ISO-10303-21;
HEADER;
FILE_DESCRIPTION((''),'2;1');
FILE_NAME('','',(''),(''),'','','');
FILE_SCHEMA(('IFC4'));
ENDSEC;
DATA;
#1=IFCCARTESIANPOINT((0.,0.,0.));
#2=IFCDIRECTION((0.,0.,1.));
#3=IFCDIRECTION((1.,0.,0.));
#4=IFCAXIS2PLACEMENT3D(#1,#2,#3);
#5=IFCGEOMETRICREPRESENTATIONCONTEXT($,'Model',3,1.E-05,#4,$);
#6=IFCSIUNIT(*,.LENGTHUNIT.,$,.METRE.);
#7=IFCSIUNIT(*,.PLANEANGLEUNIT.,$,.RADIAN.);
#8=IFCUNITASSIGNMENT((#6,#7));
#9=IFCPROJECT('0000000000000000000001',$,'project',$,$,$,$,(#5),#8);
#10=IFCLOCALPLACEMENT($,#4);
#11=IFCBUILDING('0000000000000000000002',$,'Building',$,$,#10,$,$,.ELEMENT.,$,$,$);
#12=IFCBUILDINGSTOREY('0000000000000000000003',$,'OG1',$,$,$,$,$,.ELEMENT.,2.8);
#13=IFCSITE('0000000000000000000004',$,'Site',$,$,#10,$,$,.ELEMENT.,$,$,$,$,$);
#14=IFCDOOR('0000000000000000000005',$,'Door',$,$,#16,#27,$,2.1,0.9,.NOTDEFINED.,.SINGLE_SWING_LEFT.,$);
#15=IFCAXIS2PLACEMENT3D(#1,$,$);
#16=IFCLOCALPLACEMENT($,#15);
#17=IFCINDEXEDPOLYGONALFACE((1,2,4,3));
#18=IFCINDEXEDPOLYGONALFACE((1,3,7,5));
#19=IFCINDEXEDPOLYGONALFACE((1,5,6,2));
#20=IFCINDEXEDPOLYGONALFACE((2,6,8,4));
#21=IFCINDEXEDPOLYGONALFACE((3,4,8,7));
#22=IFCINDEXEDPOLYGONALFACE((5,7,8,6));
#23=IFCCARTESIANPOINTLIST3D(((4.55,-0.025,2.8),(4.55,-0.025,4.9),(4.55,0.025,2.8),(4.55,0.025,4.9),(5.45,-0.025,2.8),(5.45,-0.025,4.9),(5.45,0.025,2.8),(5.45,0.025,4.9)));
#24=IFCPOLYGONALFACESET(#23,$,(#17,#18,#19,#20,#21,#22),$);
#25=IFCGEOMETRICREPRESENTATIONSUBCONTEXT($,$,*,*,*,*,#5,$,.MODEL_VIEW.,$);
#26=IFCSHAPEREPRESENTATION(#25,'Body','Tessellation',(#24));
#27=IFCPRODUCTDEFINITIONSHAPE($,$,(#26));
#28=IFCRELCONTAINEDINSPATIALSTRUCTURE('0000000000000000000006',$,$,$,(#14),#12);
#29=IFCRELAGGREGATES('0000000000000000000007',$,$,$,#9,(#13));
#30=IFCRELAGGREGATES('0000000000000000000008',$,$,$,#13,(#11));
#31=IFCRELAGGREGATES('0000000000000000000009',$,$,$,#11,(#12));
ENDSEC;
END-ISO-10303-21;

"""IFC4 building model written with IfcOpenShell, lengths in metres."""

from ifc_helpers import new_model, si_unit, frame, origin, origin_with_axes, origin_2d, place, context, subcontext, project, spatial, rectangle, extrude, element, save


model = new_model("IFC4")

# Units and contexts
model_context = context("Model", 3, precision=1e-05, world=origin_with_axes())
sub_context = subcontext(model_context, None, None, "MODEL_VIEW")
ifc_project = project(units=[si_unit("LENGTHUNIT", "METRE"), si_unit("PLANEANGLEUNIT", "RADIAN")], contexts=[model_context])

# Site, building, storey
placement_1 = place(None, origin_with_axes())
site = spatial("IfcSite", under=ifc_project, at=placement_1, Name="Site", CompositionType="ELEMENT")
building = spatial("IfcBuilding", under=site, at=placement_1, Name="Building", CompositionType="ELEMENT")
storey = spatial("IfcBuildingStorey", under=building, Name="OG1", CompositionType="ELEMENT", Elevation=2.8)

# Door
placement_2 = place(None, origin_with_axes())
door_placement = place(placement_2, frame((5.0, 0.0, 2.8)))
element("IfcDoor", 1, at=door_placement, inside=storey, Name="Door", OperationType="SINGLE_SWING_LEFT", OverallHeight=2.1, OverallWidth=0.9, PredefinedType="NOTDEFINED", context=sub_context, shape_type="SweptSolid", body=[
    extrude(rectangle(XDim=0.9, YDim=0.05, at=origin_2d()), origin(), (0.0, 0.0, 1.0), 2.1),
])

save(model, "model.ifc")
